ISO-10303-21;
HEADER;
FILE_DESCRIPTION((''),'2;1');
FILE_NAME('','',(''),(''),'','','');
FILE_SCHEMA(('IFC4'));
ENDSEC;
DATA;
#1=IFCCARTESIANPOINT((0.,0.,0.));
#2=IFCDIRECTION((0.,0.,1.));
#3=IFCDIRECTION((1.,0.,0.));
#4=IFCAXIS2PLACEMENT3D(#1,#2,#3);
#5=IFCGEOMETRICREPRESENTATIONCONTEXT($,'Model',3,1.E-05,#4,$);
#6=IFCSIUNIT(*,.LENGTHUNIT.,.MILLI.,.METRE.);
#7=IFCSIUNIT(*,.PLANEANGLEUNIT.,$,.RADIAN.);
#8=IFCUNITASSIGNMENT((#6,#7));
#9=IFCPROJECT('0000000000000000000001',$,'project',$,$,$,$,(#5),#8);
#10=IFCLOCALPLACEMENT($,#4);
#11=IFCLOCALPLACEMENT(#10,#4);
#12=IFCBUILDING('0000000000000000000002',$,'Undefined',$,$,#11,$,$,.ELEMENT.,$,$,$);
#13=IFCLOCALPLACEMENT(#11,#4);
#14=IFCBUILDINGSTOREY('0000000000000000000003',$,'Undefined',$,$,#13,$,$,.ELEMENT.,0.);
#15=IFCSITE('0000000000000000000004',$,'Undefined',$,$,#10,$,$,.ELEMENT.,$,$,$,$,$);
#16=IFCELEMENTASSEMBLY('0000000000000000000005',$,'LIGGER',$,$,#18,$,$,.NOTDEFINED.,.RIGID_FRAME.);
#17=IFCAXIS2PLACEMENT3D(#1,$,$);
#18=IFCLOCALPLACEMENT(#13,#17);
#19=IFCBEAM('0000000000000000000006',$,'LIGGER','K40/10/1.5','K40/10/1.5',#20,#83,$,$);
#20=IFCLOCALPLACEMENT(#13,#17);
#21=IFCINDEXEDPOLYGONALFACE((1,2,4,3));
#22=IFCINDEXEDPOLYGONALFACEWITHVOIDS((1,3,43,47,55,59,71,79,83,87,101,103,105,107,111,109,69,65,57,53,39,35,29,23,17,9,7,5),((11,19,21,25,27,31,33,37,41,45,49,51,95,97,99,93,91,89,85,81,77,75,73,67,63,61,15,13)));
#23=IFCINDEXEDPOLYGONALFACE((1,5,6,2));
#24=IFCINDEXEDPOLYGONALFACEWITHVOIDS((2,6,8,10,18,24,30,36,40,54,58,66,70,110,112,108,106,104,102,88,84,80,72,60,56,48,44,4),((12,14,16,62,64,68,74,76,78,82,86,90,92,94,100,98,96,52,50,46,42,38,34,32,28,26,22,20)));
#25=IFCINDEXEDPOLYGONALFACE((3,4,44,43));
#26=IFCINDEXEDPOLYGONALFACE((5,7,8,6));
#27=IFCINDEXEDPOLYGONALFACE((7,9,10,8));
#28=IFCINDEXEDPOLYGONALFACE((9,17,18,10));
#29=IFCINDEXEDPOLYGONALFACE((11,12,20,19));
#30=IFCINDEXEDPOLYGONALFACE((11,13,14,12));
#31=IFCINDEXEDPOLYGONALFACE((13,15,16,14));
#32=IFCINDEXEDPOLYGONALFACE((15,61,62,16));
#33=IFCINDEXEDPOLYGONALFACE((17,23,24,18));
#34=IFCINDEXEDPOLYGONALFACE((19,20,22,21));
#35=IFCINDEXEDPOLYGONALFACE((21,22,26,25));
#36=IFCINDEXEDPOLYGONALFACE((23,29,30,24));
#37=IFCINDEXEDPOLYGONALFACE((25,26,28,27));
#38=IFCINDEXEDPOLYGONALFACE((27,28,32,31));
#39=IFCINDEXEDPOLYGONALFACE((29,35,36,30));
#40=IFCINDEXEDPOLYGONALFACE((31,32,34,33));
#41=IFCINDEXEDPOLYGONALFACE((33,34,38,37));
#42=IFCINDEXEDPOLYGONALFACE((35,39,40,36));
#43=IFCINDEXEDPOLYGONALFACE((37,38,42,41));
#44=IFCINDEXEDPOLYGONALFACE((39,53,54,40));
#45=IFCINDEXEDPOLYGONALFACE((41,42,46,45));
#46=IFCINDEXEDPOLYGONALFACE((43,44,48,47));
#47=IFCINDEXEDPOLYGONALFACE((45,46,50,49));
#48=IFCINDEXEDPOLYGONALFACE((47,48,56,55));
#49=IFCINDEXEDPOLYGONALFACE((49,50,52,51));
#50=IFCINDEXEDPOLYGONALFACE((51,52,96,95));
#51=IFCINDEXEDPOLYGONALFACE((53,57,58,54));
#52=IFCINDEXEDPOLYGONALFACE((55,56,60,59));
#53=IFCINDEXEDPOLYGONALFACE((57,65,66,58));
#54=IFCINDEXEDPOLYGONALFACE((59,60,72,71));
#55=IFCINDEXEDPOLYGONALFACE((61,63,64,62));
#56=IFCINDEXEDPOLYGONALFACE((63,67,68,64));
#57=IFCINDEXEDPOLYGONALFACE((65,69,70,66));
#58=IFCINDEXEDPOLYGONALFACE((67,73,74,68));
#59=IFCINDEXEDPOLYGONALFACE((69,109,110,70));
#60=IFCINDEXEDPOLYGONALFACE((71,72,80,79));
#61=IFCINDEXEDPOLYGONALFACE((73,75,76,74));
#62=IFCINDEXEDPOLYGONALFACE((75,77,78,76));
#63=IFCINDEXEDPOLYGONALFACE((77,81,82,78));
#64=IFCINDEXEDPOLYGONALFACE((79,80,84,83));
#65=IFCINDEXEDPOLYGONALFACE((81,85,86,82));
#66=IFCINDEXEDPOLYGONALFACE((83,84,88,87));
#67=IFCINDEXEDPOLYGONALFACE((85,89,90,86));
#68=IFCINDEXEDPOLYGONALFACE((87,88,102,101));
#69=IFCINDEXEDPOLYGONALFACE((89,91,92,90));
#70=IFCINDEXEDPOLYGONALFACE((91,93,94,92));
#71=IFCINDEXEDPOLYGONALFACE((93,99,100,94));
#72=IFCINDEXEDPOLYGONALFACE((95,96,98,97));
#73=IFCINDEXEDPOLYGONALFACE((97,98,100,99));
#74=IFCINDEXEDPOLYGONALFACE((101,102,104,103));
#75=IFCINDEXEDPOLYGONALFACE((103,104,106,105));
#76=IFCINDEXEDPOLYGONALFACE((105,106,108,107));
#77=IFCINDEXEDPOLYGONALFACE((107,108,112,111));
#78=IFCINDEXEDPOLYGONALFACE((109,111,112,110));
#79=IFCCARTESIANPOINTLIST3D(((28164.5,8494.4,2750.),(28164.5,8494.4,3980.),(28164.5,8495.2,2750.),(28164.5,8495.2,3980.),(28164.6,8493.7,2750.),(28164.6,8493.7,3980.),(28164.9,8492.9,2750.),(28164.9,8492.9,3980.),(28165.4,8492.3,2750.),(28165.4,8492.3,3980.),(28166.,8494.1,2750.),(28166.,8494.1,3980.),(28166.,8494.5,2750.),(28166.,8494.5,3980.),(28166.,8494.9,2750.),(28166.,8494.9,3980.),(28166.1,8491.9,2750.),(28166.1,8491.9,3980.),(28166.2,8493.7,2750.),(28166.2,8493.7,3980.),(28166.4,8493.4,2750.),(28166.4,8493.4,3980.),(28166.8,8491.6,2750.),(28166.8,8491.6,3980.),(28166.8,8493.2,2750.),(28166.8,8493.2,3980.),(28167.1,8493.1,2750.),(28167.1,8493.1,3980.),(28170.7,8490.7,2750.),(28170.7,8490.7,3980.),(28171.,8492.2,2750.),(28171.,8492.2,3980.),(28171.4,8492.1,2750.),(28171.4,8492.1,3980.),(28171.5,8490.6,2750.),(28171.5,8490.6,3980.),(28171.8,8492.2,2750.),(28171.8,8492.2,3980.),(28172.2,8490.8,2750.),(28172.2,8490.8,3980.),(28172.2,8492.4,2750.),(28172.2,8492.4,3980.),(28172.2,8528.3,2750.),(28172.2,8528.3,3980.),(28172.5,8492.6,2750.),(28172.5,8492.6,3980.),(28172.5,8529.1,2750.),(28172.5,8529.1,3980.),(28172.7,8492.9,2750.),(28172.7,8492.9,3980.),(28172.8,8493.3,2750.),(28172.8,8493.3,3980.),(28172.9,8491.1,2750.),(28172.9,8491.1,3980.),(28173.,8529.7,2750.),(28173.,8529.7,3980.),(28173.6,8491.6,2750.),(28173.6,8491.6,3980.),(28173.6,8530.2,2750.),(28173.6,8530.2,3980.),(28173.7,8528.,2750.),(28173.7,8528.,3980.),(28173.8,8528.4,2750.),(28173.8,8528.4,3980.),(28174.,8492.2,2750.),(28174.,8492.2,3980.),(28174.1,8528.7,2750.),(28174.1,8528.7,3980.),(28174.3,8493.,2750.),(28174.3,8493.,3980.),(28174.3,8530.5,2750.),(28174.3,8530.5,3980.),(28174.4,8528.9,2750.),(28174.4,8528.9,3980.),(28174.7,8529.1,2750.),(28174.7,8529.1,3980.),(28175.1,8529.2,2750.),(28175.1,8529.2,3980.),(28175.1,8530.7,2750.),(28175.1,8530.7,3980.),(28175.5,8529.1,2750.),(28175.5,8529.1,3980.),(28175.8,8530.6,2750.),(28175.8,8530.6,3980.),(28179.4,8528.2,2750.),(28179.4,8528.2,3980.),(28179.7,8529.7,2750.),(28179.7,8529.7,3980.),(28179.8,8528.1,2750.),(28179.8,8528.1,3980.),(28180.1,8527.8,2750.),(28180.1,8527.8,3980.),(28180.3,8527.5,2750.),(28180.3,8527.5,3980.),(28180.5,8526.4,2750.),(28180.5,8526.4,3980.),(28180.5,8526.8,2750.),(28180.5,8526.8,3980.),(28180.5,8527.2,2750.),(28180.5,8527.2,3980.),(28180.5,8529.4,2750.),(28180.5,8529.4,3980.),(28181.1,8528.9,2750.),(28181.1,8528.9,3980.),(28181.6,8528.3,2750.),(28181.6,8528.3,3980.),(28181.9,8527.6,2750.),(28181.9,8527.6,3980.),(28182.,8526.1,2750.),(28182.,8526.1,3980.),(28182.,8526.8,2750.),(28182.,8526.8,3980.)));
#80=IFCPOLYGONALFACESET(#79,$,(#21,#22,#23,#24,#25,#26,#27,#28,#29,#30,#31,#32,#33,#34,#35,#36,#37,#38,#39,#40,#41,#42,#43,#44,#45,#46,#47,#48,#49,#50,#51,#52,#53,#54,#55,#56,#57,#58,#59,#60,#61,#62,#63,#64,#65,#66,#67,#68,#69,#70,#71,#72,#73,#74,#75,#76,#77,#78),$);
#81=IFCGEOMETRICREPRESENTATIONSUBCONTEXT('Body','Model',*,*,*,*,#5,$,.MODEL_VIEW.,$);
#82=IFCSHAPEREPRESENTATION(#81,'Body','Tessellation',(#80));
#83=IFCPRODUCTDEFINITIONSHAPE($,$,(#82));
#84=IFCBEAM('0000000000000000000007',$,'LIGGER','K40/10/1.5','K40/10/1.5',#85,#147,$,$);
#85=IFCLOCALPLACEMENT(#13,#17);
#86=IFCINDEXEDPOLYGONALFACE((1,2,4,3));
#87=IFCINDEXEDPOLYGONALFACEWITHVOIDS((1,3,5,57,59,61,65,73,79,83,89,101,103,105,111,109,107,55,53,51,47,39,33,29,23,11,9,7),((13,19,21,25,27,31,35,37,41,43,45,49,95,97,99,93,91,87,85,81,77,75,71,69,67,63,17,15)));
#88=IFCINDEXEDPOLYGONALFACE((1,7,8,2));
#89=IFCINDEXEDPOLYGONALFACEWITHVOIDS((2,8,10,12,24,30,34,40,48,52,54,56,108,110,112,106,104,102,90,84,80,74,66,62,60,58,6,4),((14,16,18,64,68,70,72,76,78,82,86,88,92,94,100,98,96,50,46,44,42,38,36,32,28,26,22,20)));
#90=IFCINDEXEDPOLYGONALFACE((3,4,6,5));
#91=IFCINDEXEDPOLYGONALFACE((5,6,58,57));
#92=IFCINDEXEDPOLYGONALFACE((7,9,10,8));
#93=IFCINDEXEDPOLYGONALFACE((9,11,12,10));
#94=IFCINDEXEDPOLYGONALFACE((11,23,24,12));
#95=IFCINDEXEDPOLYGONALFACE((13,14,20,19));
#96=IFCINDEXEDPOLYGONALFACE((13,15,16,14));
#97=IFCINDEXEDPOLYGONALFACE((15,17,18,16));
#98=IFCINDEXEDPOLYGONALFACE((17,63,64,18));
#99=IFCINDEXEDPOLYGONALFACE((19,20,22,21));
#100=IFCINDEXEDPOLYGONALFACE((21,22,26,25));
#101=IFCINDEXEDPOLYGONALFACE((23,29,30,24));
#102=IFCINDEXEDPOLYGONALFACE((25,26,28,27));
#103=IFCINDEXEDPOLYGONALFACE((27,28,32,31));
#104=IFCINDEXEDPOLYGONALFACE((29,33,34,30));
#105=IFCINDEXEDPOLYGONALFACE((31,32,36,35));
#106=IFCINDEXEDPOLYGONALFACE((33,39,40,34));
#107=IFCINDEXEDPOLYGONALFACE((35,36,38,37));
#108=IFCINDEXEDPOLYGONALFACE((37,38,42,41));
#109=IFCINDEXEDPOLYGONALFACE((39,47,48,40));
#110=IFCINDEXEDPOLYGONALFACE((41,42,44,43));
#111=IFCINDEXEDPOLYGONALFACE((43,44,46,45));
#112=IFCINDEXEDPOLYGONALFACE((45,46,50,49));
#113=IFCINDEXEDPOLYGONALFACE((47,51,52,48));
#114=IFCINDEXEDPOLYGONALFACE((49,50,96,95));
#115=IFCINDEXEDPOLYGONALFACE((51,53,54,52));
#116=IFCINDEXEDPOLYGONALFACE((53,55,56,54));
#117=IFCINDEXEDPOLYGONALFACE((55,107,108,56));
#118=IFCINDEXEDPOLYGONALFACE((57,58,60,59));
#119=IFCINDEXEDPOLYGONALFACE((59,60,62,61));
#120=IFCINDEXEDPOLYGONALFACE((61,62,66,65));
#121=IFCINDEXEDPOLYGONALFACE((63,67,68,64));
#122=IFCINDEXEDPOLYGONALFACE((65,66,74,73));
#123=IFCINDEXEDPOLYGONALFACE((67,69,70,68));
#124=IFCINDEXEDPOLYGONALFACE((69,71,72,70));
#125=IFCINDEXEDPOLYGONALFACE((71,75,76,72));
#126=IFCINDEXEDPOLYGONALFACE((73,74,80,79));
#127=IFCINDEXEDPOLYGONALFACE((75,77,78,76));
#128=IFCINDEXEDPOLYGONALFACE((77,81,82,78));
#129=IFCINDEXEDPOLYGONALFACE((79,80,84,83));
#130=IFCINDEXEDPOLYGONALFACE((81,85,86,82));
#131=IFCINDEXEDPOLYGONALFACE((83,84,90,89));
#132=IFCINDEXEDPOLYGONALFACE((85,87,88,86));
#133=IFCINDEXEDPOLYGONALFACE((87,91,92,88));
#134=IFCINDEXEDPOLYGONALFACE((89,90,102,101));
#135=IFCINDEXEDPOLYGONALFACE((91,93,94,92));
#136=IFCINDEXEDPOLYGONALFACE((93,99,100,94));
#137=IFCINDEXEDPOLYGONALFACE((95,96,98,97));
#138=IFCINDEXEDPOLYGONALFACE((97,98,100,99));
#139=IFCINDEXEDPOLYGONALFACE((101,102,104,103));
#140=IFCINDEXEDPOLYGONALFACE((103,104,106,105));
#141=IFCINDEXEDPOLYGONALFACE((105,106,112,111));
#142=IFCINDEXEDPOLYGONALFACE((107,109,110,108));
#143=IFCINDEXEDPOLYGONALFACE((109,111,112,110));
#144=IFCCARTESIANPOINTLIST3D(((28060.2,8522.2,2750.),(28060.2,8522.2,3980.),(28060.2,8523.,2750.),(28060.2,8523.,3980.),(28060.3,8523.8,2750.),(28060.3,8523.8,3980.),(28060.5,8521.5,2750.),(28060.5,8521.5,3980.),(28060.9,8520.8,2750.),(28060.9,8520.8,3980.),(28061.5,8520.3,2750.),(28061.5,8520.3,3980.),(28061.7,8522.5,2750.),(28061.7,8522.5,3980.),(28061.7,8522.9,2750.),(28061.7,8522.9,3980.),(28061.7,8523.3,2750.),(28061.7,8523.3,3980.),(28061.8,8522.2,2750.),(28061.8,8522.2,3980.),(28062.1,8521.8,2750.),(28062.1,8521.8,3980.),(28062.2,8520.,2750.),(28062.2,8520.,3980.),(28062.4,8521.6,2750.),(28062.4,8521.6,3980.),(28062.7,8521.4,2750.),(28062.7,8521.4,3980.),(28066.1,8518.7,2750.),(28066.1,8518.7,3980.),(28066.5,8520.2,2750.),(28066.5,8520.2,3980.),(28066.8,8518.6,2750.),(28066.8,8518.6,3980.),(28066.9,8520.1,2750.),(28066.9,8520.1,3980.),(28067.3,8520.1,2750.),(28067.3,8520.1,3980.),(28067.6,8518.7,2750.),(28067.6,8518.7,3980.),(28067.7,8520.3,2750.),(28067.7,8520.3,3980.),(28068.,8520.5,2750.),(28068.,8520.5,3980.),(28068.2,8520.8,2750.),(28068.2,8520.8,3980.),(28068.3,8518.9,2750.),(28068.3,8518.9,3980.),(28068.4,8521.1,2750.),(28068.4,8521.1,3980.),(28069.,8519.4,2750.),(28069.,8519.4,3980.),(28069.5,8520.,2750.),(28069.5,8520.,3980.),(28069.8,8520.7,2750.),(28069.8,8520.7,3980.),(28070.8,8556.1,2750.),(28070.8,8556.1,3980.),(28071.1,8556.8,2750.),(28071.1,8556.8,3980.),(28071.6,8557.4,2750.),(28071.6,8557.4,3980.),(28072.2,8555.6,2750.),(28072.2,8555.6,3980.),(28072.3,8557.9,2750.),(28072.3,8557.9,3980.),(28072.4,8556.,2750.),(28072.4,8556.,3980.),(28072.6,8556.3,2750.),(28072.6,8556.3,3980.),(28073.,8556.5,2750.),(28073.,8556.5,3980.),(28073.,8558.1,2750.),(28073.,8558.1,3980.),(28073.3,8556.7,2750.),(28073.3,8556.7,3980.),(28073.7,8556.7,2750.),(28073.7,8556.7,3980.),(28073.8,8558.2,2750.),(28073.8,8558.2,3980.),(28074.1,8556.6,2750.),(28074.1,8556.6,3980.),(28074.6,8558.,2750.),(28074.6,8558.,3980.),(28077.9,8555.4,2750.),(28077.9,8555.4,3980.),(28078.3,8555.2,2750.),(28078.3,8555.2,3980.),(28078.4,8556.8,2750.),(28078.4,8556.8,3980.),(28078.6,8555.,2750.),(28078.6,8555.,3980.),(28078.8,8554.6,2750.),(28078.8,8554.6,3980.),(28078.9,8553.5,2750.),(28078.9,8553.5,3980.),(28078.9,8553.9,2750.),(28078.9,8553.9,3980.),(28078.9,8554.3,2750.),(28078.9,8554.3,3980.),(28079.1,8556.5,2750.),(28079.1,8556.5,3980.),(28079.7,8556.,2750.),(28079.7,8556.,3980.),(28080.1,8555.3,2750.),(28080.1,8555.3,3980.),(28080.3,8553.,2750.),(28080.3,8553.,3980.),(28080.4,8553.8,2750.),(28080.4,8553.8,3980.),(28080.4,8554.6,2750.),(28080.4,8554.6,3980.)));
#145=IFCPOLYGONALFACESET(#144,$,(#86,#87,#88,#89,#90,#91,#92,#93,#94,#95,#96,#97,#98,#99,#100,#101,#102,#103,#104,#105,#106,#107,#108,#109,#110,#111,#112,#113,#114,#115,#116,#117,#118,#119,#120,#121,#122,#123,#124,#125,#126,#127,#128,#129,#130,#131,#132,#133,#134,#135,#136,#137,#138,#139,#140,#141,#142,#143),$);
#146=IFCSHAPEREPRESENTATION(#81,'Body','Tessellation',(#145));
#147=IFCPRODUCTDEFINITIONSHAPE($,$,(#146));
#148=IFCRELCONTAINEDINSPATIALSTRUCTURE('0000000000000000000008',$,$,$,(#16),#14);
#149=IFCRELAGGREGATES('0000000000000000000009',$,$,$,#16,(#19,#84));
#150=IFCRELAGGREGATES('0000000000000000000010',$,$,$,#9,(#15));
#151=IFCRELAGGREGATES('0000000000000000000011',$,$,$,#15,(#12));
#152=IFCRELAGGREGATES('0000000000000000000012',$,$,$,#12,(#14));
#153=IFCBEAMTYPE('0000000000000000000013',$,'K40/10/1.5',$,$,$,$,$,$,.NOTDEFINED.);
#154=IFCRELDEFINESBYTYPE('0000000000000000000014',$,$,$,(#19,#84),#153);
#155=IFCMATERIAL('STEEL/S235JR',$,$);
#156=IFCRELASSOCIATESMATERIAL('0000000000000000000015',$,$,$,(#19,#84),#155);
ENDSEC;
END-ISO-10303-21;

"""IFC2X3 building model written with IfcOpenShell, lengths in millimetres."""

from ifc_helpers import new_model, si_unit, frame, origin_with_axes, origin_2d_with_axis, place, context, subcontext, project, spatial, hollow_rectangle, extrude, material, type_object, element, aggregate, save


model = new_model("IFC2X3")

# Units and contexts
model_context = context("Model", 3, precision=1e-05, world=origin_with_axes())
body_context = subcontext(model_context, "Body", "Model", "MODEL_VIEW")
ifc_project = project(units=[si_unit("LENGTHUNIT", "METRE", prefix="MILLI"), si_unit("PLANEANGLEUNIT", "RADIAN")], contexts=[model_context])

# Site, building, storey
site_placement = place(None, origin_with_axes())
site = spatial("IfcSite", under=ifc_project, at=site_placement, Name="Undefined", CompositionType="ELEMENT")
building_placement = place(site_placement, origin_with_axes())
building = spatial("IfcBuilding", under=site, at=building_placement, Name="Undefined", CompositionType="ELEMENT")
storey_placement = place(building_placement, origin_with_axes())
storey = spatial("IfcBuildingStorey", under=building, at=storey_placement, Name="Undefined", CompositionType="ELEMENT", Elevation=0.0)

# Element assembly, beams
ifc_material_1 = material(Name="STEEL/S235JR")
assembly_1_placement = place(storey_placement, origin_with_axes())
assembly_1 = element("IfcElementAssembly", 1, at=assembly_1_placement, inside=storey, Name="LIGGER", AssemblyPlace="NOTDEFINED", PredefinedType="RIGID_FRAME")
beam_type_1 = type_object("IfcBeamType", Name="K40/10/1.5", PredefinedType="NOTDEFINED")
beam_1_placement = place(assembly_1_placement, frame((28173.3, 8510.6, 3980.0), z_axis=(0.226215, 0.974077, 0.0), x_axis=(0.0, 0.0, -1.0)))
beam_1 = element("IfcBeam", 2, at=beam_1_placement, type_object=beam_type_1, material=ifc_material_1, Name="LIGGER", Description="K40/10/1.5", ObjectType="K40/10/1.5", context=body_context, shape_type="SweptSolid", body=[
    extrude(hollow_rectangle(XDim=10.0, YDim=40.0, WallThickness=1.5, InnerFilletRadius=1.5, OuterFilletRadius=3.0, at=origin_2d_with_axis()), frame((1230.0, 0.0, 0.0), z_axis=(-1.0, 0.0, 0.0), x_axis=(0.0, -1.0, 0.0)), (0.0, 0.0, 1.0), 1230.0),
])
beam_2_placement = place(assembly_1_placement, frame((28070.3, 8538.4, 3980.0), z_axis=(0.307761, 0.951464, 0.0), x_axis=(0.0, 0.0, -1.0)))
beam_2 = element("IfcBeam", 3, at=beam_2_placement, type_object=beam_type_1, material=ifc_material_1, Name="LIGGER", Description="K40/10/1.5", ObjectType="K40/10/1.5", context=body_context, shape_type="SweptSolid", body=[
    extrude(hollow_rectangle(XDim=10.0, YDim=40.0, WallThickness=1.5, InnerFilletRadius=1.5, OuterFilletRadius=3.0, at=origin_2d_with_axis()), frame((1230.0, 0.0, 0.0), z_axis=(-1.0, 0.0, 0.0), x_axis=(0.0, -1.0, 0.0)), (0.0, 0.0, 1.0), 1230.0),
])

aggregate(assembly_1, [beam_1, beam_2])

save(model, "model.ifc")
